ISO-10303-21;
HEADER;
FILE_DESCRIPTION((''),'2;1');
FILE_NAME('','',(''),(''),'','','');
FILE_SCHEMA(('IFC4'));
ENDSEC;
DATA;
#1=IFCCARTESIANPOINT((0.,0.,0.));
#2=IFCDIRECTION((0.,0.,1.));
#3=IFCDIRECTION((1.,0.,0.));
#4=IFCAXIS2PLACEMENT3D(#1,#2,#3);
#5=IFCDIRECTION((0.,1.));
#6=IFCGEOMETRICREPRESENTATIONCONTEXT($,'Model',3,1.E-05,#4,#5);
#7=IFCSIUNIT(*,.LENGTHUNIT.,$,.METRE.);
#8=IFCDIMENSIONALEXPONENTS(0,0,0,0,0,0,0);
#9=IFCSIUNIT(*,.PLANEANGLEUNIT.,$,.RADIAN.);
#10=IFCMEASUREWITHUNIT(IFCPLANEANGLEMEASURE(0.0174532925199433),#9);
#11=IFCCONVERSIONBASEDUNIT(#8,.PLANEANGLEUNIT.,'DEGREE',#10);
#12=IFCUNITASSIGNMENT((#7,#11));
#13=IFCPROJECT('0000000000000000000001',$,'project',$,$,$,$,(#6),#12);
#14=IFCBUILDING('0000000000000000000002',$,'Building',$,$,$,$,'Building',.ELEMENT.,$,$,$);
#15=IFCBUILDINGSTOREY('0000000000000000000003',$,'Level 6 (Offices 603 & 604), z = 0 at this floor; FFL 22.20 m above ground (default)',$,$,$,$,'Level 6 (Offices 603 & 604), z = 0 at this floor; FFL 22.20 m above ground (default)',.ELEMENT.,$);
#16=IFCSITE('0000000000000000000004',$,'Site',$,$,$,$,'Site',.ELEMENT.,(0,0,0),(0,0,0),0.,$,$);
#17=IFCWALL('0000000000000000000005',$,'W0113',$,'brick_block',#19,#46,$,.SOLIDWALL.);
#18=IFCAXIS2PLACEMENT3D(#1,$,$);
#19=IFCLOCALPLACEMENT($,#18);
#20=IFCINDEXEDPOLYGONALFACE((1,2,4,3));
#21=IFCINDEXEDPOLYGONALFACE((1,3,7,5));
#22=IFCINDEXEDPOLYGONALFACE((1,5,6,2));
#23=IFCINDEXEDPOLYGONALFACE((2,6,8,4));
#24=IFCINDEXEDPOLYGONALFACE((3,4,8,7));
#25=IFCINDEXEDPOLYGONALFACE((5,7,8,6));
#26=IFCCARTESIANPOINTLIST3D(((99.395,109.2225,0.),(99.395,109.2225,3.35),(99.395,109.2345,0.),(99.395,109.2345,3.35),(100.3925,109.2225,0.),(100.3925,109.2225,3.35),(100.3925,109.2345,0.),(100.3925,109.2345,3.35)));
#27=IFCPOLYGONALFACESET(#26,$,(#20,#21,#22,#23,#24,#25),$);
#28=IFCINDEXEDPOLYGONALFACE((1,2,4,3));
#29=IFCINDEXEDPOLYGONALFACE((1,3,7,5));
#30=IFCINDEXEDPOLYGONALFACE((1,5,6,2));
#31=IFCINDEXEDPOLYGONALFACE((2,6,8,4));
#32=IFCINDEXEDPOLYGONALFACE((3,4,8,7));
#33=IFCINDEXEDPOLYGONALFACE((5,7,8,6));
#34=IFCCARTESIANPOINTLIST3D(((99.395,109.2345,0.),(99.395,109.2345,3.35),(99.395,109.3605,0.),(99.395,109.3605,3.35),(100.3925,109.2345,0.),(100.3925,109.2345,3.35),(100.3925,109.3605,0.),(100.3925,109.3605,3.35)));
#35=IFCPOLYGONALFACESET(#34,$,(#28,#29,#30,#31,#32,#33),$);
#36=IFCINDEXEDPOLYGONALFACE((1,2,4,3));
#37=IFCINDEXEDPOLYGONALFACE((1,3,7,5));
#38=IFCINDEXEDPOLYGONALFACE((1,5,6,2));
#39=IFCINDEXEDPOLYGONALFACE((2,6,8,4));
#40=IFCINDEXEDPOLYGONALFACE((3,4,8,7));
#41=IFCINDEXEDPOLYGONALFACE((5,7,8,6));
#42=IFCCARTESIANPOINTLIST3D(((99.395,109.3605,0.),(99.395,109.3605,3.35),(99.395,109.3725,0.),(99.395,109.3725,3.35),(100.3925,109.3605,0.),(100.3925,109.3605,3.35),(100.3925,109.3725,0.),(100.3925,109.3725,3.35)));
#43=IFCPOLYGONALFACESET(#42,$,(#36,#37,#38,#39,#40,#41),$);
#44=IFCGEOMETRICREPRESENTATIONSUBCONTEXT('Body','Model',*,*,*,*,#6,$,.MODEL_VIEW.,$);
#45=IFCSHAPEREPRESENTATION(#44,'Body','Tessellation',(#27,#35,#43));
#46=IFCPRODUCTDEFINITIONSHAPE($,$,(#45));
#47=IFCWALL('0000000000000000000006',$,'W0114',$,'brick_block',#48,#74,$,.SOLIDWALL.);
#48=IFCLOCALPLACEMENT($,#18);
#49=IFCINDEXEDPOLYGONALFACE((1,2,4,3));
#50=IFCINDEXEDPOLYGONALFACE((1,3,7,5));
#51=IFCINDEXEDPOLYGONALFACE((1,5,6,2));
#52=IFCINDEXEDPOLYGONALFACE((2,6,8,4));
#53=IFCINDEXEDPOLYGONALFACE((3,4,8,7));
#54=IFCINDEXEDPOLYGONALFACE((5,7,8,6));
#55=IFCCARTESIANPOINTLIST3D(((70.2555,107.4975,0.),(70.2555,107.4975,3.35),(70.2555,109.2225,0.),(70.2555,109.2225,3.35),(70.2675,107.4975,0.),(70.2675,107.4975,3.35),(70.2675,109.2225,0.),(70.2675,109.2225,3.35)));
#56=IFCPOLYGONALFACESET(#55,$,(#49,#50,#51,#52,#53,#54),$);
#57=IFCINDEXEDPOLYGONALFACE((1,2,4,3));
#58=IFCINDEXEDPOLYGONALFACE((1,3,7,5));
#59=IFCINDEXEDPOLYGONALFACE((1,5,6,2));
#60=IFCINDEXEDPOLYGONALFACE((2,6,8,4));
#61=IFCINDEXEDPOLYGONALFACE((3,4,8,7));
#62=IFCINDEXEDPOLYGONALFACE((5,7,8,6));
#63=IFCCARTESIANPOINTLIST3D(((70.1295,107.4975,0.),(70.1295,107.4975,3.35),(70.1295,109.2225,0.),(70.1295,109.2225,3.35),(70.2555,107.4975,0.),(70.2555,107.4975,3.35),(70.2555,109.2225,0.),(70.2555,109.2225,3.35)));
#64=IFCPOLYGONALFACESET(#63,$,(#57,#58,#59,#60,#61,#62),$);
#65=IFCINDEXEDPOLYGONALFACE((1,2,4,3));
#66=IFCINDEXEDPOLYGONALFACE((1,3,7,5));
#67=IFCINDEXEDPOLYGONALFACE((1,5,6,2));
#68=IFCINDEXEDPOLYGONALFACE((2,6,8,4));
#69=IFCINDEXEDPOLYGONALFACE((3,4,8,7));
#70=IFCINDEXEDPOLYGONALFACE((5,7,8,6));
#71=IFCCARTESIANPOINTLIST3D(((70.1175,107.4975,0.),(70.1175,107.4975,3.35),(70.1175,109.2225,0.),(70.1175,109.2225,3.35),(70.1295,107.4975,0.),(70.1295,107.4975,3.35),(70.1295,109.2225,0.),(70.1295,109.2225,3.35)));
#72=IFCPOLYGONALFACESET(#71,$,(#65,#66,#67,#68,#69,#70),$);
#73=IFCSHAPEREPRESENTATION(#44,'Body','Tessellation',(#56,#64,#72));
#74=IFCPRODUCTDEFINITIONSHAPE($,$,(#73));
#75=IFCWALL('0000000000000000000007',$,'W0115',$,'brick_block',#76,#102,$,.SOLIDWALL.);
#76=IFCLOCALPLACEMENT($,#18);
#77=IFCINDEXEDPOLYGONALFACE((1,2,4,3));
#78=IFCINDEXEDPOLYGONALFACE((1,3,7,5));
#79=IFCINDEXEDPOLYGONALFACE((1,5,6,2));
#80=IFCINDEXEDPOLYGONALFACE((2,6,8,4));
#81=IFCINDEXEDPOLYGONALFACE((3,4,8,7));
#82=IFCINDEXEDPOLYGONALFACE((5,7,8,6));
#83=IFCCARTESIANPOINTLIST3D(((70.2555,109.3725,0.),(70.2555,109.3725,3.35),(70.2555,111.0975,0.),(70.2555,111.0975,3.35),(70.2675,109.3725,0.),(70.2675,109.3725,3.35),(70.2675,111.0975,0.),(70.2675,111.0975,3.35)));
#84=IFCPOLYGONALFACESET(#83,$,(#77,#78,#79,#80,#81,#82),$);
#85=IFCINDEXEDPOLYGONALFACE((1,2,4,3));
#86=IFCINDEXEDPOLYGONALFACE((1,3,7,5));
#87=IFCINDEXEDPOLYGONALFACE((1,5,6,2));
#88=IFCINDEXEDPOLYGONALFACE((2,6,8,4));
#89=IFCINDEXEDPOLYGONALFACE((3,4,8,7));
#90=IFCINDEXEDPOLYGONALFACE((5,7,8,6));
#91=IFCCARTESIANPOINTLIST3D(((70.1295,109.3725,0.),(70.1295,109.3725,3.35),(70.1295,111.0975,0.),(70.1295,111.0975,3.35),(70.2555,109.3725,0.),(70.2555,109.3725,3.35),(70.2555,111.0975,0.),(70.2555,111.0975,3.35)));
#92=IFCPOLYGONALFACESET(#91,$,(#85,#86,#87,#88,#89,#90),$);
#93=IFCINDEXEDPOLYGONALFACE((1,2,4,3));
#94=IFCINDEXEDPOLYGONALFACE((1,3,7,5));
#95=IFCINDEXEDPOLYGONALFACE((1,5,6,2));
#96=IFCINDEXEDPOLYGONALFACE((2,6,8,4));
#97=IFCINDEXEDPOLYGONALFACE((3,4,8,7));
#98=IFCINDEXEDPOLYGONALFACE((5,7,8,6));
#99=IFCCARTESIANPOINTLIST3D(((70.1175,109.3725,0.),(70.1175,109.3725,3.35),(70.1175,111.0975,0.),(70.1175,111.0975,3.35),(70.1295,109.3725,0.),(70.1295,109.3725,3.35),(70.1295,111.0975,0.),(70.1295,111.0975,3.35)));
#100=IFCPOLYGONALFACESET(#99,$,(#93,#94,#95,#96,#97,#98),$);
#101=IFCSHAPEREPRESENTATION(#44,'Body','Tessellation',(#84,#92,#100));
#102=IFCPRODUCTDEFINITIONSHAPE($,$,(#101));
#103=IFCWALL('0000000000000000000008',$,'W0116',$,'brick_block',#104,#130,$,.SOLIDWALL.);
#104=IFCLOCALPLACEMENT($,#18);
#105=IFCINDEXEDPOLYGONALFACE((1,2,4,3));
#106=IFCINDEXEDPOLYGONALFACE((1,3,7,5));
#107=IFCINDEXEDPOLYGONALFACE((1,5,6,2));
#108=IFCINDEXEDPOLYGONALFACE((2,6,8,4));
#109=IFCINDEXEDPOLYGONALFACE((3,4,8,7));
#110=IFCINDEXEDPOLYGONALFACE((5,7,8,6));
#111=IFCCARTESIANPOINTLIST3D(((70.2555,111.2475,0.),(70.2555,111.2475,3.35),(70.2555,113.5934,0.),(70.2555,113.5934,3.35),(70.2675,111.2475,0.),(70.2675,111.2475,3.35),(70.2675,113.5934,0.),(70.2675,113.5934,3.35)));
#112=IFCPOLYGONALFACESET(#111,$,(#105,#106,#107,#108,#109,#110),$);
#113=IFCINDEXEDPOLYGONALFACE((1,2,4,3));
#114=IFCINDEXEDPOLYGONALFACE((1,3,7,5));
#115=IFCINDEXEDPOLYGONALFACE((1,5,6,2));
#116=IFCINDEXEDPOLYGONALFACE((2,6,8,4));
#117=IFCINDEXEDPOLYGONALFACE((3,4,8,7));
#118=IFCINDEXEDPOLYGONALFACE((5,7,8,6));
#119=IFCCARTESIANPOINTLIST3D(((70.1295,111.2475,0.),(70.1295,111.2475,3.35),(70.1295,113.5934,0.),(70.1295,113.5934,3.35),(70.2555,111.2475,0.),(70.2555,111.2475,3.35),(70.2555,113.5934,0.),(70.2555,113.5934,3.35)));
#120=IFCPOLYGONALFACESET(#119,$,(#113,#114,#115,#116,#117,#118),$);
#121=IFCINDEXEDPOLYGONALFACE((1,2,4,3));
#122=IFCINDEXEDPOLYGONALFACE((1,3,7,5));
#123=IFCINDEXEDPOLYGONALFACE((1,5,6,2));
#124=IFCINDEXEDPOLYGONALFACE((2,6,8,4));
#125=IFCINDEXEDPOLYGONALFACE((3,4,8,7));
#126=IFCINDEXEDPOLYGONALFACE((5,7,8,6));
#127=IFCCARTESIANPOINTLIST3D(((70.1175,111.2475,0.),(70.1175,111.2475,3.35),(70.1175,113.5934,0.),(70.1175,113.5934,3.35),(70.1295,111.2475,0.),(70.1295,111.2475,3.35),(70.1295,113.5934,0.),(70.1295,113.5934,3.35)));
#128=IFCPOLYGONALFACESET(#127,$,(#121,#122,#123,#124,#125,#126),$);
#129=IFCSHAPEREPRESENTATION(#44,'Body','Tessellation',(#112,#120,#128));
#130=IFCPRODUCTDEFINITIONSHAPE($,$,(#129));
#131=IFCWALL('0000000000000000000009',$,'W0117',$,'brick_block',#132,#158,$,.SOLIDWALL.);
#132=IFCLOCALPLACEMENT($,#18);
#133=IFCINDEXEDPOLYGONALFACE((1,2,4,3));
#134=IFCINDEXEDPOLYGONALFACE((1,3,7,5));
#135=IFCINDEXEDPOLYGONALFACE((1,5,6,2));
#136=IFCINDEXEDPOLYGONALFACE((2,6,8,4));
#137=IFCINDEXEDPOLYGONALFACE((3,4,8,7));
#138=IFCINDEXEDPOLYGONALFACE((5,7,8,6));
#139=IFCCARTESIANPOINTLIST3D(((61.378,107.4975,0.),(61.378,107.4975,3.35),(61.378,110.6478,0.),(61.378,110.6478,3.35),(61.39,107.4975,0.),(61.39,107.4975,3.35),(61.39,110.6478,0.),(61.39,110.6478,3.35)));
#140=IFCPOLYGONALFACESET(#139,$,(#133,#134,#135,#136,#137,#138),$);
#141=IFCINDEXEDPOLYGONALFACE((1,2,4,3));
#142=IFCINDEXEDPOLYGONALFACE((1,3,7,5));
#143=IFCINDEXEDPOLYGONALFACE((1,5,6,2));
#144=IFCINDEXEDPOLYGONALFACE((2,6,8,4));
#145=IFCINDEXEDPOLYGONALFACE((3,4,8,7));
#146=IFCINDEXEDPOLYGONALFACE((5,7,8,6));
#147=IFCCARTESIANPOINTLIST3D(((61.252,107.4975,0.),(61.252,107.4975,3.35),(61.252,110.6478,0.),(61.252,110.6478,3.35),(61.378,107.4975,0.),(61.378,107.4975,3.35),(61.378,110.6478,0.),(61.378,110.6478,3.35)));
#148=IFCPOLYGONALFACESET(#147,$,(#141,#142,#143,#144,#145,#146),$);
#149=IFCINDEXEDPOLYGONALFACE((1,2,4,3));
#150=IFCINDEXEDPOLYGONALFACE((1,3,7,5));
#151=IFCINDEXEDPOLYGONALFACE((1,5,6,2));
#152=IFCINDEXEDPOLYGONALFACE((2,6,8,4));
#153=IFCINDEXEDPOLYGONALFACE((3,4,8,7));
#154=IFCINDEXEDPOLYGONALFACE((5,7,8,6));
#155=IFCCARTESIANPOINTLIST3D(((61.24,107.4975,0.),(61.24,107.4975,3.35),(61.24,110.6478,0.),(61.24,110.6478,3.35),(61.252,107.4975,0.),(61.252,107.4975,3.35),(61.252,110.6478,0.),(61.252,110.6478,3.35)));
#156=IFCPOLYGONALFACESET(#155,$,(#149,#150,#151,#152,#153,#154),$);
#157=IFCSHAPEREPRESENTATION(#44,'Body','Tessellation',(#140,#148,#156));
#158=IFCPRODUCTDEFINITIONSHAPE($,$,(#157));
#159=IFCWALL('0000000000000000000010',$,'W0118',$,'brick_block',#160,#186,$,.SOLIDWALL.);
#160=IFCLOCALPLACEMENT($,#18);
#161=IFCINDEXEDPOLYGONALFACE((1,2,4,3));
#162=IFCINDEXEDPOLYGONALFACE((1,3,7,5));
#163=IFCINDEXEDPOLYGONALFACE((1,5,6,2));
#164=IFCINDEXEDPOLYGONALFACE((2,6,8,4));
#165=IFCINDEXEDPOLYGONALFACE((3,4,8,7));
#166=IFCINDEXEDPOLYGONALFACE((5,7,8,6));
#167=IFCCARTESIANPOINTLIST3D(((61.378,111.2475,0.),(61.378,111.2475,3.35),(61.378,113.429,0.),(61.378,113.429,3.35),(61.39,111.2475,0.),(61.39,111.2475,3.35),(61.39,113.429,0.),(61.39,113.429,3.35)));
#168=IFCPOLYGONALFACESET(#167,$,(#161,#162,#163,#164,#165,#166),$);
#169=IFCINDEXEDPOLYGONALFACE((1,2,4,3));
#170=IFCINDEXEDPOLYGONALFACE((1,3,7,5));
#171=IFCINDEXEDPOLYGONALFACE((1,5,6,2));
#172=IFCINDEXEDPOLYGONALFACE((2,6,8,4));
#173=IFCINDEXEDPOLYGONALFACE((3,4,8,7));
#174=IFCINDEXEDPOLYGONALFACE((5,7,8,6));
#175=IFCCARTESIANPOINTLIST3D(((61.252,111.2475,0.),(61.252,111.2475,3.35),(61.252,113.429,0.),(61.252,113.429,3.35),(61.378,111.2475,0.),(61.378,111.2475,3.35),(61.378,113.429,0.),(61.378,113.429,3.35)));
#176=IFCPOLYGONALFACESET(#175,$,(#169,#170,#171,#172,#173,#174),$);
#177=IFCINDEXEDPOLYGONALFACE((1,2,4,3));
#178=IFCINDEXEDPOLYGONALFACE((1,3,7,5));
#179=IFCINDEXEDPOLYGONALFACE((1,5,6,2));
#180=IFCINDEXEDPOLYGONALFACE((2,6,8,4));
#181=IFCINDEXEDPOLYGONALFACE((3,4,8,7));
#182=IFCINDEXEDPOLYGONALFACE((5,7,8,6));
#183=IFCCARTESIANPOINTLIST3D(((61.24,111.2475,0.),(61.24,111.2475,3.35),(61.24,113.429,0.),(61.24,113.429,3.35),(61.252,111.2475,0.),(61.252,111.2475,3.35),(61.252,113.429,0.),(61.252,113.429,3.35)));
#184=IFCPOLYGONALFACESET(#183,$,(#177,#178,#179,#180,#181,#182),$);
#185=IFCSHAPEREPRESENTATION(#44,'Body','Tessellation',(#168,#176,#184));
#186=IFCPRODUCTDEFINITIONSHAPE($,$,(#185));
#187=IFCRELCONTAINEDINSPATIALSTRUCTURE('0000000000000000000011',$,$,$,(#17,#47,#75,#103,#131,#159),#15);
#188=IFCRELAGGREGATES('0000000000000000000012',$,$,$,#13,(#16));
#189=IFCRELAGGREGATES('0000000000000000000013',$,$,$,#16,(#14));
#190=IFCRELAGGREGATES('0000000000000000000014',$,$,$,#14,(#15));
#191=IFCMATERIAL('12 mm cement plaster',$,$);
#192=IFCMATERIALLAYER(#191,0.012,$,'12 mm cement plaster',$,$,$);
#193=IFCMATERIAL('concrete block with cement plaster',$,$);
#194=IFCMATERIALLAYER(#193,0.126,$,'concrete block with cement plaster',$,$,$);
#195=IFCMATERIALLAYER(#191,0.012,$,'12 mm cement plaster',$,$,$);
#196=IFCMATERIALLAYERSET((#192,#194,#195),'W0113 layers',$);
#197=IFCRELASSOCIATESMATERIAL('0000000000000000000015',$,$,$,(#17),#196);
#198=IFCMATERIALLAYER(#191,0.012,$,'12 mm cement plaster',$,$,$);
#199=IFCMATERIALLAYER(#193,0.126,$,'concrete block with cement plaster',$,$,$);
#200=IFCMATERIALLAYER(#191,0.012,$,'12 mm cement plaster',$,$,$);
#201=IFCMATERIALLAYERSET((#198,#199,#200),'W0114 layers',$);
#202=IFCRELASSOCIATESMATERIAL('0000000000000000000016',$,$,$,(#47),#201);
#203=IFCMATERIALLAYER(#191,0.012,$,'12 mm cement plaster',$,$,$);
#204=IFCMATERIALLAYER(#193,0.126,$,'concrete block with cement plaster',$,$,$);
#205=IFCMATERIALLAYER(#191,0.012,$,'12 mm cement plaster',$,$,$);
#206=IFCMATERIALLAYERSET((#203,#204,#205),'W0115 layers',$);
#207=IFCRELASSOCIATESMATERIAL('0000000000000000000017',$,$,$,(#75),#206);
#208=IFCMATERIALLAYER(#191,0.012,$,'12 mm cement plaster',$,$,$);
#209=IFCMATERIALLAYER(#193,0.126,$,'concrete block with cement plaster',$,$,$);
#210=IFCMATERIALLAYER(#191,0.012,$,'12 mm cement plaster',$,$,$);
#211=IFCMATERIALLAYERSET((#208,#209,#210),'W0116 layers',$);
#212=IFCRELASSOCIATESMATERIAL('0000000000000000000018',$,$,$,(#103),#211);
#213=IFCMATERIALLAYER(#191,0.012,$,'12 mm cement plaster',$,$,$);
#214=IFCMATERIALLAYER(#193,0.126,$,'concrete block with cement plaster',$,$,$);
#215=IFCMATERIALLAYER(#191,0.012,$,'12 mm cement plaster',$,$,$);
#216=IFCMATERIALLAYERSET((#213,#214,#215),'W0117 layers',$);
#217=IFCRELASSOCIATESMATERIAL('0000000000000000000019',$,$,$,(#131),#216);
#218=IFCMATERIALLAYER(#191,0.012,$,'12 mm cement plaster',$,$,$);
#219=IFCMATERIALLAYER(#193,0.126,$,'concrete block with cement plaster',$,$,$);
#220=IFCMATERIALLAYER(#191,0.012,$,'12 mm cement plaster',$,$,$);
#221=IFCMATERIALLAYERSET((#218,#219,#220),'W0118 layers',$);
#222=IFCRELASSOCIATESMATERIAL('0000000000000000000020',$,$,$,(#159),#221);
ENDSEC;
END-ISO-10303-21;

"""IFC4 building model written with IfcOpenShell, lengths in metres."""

from ifc_helpers import new_model, entity, si_unit, converted_unit, direction, frame, frame_2d, origin_with_axes, origin_2d_with_axis, place, context, subcontext, project, spatial, rectangle, extrude, material, layer, layer_set, layer_usage, element, save


model = new_model("IFC4")

# Units and contexts
model_context = context("Model", 3, precision=1e-05, world=origin_with_axes(), true_north=direction((0.0, 1.0)))
body_context = subcontext(model_context, "Body", "Model", "MODEL_VIEW")
ifc_project = project(units=[si_unit("LENGTHUNIT", "METRE"), converted_unit("PLANEANGLEUNIT", "DEGREE", entity("IfcPlaneAngleMeasure", 0.0174532925199433), si_unit("PLANEANGLEUNIT", "RADIAN"), dimensions=[0, 0, 0, 0, 0, 0, 0])], contexts=[model_context])

# Site, building, storey
site = spatial("IfcSite", under=ifc_project, Name="Site", LongName="Site", CompositionType="ELEMENT", RefLatitude=(0, 0, 0), RefLongitude=(0, 0, 0), RefElevation=0.0)
building = spatial("IfcBuilding", under=site, Name="Building", LongName="Building", CompositionType="ELEMENT")
storey = spatial("IfcBuildingStorey", under=building, Name="Level 6 (Offices 603 & 604), z = 0 at this floor; FFL 22.20 m above ground (default)", LongName="Level 6 (Offices 603 & 604), z = 0 at this floor; FFL 22.20 m above ground (default)", CompositionType="ELEMENT")

# Shared definitions
placement = place(None, origin_with_axes())

# Walls
ifc_material_1 = material(Name="12 mm cement plaster")
ifc_material_2 = material(Name="concrete block with cement plaster")
ifc_layer_1 = layer(ifc_material_1, 0.012, Name="12 mm cement plaster")
ifc_layer_2 = layer(ifc_material_2, 0.126, Name="concrete block with cement plaster")
ifc_layer_3 = layer(ifc_material_1, 0.012, Name="12 mm cement plaster")
ifc_layer_set_1 = layer_set([ifc_layer_1, ifc_layer_2, ifc_layer_3], Name="W0113 layers")
ifc_layer_usage_1 = layer_usage(ifc_layer_set_1, "AXIS2", "POSITIVE", -0.075)
element("IfcWall", 1, at=placement, inside=storey, material=ifc_layer_usage_1, Name="W0113", ObjectType="brick_block", PredefinedType="SOLIDWALL", context=body_context, shape_type="SweptSolid", body=[
    extrude(rectangle(XDim=0.9975, YDim=0.012, at=origin_2d_with_axis()), frame((99.8937, 109.2285, 0.0), z_axis=(0.0, 0.0, 1.0), x_axis=(1.0, 0.0, 0.0)), (0.0, 0.0, 1.0), 3.35),
    extrude(rectangle(XDim=0.9975, YDim=0.126, at=frame_2d((0.0, 0.069), x_axis=(1.0, 0.0))), frame((99.8937, 109.2285, 0.0), z_axis=(0.0, 0.0, 1.0), x_axis=(1.0, 0.0, 0.0)), (0.0, 0.0, 1.0), 3.35),
    extrude(rectangle(XDim=0.9975, YDim=0.012, at=frame_2d((0.0, 0.138), x_axis=(1.0, 0.0))), frame((99.8937, 109.2285, 0.0), z_axis=(0.0, 0.0, 1.0), x_axis=(1.0, 0.0, 0.0)), (0.0, 0.0, 1.0), 3.35),
])
ifc_layer_4 = layer(ifc_material_1, 0.012, Name="12 mm cement plaster")
ifc_layer_5 = layer(ifc_material_2, 0.126, Name="concrete block with cement plaster")
ifc_layer_6 = layer(ifc_material_1, 0.012, Name="12 mm cement plaster")
ifc_layer_set_2 = layer_set([ifc_layer_4, ifc_layer_5, ifc_layer_6], Name="W0114 layers")
ifc_layer_usage_2 = layer_usage(ifc_layer_set_2, "AXIS2", "POSITIVE", -0.075)
element("IfcWall", 2, at=placement, inside=storey, material=ifc_layer_usage_2, Name="W0114", ObjectType="brick_block", PredefinedType="SOLIDWALL", context=body_context, shape_type="SweptSolid", body=[
    extrude(rectangle(XDim=1.725, YDim=0.012, at=frame_2d((0.0, 0.0), x_axis=(0.0, 1.0))), frame((70.2615, 108.36, 0.0), z_axis=(0.0, 0.0, 1.0), x_axis=(1.0, 0.0, 0.0)), (0.0, 0.0, 1.0), 3.35),
    extrude(rectangle(XDim=1.725, YDim=0.126, at=frame_2d((-0.069, 0.0), x_axis=(0.0, 1.0))), frame((70.2615, 108.36, 0.0), z_axis=(0.0, 0.0, 1.0), x_axis=(1.0, 0.0, 0.0)), (0.0, 0.0, 1.0), 3.35),
    extrude(rectangle(XDim=1.725, YDim=0.012, at=frame_2d((-0.138, 0.0), x_axis=(0.0, 1.0))), frame((70.2615, 108.36, 0.0), z_axis=(0.0, 0.0, 1.0), x_axis=(1.0, 0.0, 0.0)), (0.0, 0.0, 1.0), 3.35),
])
ifc_layer_7 = layer(ifc_material_1, 0.012, Name="12 mm cement plaster")
ifc_layer_8 = layer(ifc_material_2, 0.126, Name="concrete block with cement plaster")
ifc_layer_9 = layer(ifc_material_1, 0.012, Name="12 mm cement plaster")
ifc_layer_set_3 = layer_set([ifc_layer_7, ifc_layer_8, ifc_layer_9], Name="W0115 layers")
ifc_layer_usage_3 = layer_usage(ifc_layer_set_3, "AXIS2", "POSITIVE", -0.075)
element("IfcWall", 3, at=placement, inside=storey, material=ifc_layer_usage_3, Name="W0115", ObjectType="brick_block", PredefinedType="SOLIDWALL", context=body_context, shape_type="SweptSolid", body=[
    extrude(rectangle(XDim=1.725, YDim=0.012, at=frame_2d((0.0, 0.0), x_axis=(0.0, 1.0))), frame((70.2615, 110.235, 0.0), z_axis=(0.0, 0.0, 1.0), x_axis=(1.0, 0.0, 0.0)), (0.0, 0.0, 1.0), 3.35),
    extrude(rectangle(XDim=1.725, YDim=0.126, at=frame_2d((-0.069, 0.0), x_axis=(0.0, 1.0))), frame((70.2615, 110.235, 0.0), z_axis=(0.0, 0.0, 1.0), x_axis=(1.0, 0.0, 0.0)), (0.0, 0.0, 1.0), 3.35),
    extrude(rectangle(XDim=1.725, YDim=0.012, at=frame_2d((-0.138, 0.0), x_axis=(0.0, 1.0))), frame((70.2615, 110.235, 0.0), z_axis=(0.0, 0.0, 1.0), x_axis=(1.0, 0.0, 0.0)), (0.0, 0.0, 1.0), 3.35),
])
ifc_layer_10 = layer(ifc_material_1, 0.012, Name="12 mm cement plaster")
ifc_layer_11 = layer(ifc_material_2, 0.126, Name="concrete block with cement plaster")
ifc_layer_12 = layer(ifc_material_1, 0.012, Name="12 mm cement plaster")
ifc_layer_set_4 = layer_set([ifc_layer_10, ifc_layer_11, ifc_layer_12], Name="W0116 layers")
ifc_layer_usage_4 = layer_usage(ifc_layer_set_4, "AXIS2", "POSITIVE", -0.075)
element("IfcWall", 4, at=placement, inside=storey, material=ifc_layer_usage_4, Name="W0116", ObjectType="brick_block", PredefinedType="SOLIDWALL", context=body_context, shape_type="SweptSolid", body=[
    extrude(rectangle(XDim=2.3459, YDim=0.012, at=frame_2d((0.0, 0.0), x_axis=(0.0, 1.0))), frame((70.2615, 112.4205, 0.0), z_axis=(0.0, 0.0, 1.0), x_axis=(1.0, 0.0, 0.0)), (0.0, 0.0, 1.0), 3.35),
    extrude(rectangle(XDim=2.3459, YDim=0.126, at=frame_2d((-0.069, 0.0), x_axis=(0.0, 1.0))), frame((70.2615, 112.4205, 0.0), z_axis=(0.0, 0.0, 1.0), x_axis=(1.0, 0.0, 0.0)), (0.0, 0.0, 1.0), 3.35),
    extrude(rectangle(XDim=2.3459, YDim=0.012, at=frame_2d((-0.138, 0.0), x_axis=(0.0, 1.0))), frame((70.2615, 112.4205, 0.0), z_axis=(0.0, 0.0, 1.0), x_axis=(1.0, 0.0, 0.0)), (0.0, 0.0, 1.0), 3.35),
])
ifc_layer_13 = layer(ifc_material_1, 0.012, Name="12 mm cement plaster")
ifc_layer_14 = layer(ifc_material_2, 0.126, Name="concrete block with cement plaster")
ifc_layer_15 = layer(ifc_material_1, 0.012, Name="12 mm cement plaster")
ifc_layer_set_5 = layer_set([ifc_layer_13, ifc_layer_14, ifc_layer_15], Name="W0117 layers")
ifc_layer_usage_5 = layer_usage(ifc_layer_set_5, "AXIS2", "POSITIVE", -0.075)
element("IfcWall", 5, at=placement, inside=storey, material=ifc_layer_usage_5, Name="W0117", ObjectType="brick_block", PredefinedType="SOLIDWALL", context=body_context, shape_type="SweptSolid", body=[
    extrude(rectangle(XDim=3.1503, YDim=0.012, at=frame_2d((0.0, 0.0), x_axis=(0.0, 1.0))), frame((61.384, 109.0726, 0.0), z_axis=(0.0, 0.0, 1.0), x_axis=(1.0, 0.0, 0.0)), (0.0, 0.0, 1.0), 3.35),
    extrude(rectangle(XDim=3.1503, YDim=0.126, at=frame_2d((-0.069, 0.0), x_axis=(0.0, 1.0))), frame((61.384, 109.0726, 0.0), z_axis=(0.0, 0.0, 1.0), x_axis=(1.0, 0.0, 0.0)), (0.0, 0.0, 1.0), 3.35),
    extrude(rectangle(XDim=3.1503, YDim=0.012, at=frame_2d((-0.138, 0.0), x_axis=(0.0, 1.0))), frame((61.384, 109.0726, 0.0), z_axis=(0.0, 0.0, 1.0), x_axis=(1.0, 0.0, 0.0)), (0.0, 0.0, 1.0), 3.35),
])
ifc_layer_16 = layer(ifc_material_1, 0.012, Name="12 mm cement plaster")
ifc_layer_17 = layer(ifc_material_2, 0.126, Name="concrete block with cement plaster")
ifc_layer_18 = layer(ifc_material_1, 0.012, Name="12 mm cement plaster")
ifc_layer_set_6 = layer_set([ifc_layer_16, ifc_layer_17, ifc_layer_18], Name="W0118 layers")
ifc_layer_usage_6 = layer_usage(ifc_layer_set_6, "AXIS2", "POSITIVE", -0.075)
element("IfcWall", 6, at=placement, inside=storey, material=ifc_layer_usage_6, Name="W0118", ObjectType="brick_block", PredefinedType="SOLIDWALL", context=body_context, shape_type="SweptSolid", body=[
    extrude(rectangle(XDim=2.1815, YDim=0.012, at=frame_2d((0.0, 0.0), x_axis=(0.0, 1.0))), frame((61.384, 112.3383, 0.0), z_axis=(0.0, 0.0, 1.0), x_axis=(1.0, 0.0, 0.0)), (0.0, 0.0, 1.0), 3.35),
    extrude(rectangle(XDim=2.1815, YDim=0.126, at=frame_2d((-0.069, 0.0), x_axis=(0.0, 1.0))), frame((61.384, 112.3383, 0.0), z_axis=(0.0, 0.0, 1.0), x_axis=(1.0, 0.0, 0.0)), (0.0, 0.0, 1.0), 3.35),
    extrude(rectangle(XDim=2.1815, YDim=0.012, at=frame_2d((-0.138, 0.0), x_axis=(0.0, 1.0))), frame((61.384, 112.3383, 0.0), z_axis=(0.0, 0.0, 1.0), x_axis=(1.0, 0.0, 0.0)), (0.0, 0.0, 1.0), 3.35),
])

save(model, "model.ifc")
